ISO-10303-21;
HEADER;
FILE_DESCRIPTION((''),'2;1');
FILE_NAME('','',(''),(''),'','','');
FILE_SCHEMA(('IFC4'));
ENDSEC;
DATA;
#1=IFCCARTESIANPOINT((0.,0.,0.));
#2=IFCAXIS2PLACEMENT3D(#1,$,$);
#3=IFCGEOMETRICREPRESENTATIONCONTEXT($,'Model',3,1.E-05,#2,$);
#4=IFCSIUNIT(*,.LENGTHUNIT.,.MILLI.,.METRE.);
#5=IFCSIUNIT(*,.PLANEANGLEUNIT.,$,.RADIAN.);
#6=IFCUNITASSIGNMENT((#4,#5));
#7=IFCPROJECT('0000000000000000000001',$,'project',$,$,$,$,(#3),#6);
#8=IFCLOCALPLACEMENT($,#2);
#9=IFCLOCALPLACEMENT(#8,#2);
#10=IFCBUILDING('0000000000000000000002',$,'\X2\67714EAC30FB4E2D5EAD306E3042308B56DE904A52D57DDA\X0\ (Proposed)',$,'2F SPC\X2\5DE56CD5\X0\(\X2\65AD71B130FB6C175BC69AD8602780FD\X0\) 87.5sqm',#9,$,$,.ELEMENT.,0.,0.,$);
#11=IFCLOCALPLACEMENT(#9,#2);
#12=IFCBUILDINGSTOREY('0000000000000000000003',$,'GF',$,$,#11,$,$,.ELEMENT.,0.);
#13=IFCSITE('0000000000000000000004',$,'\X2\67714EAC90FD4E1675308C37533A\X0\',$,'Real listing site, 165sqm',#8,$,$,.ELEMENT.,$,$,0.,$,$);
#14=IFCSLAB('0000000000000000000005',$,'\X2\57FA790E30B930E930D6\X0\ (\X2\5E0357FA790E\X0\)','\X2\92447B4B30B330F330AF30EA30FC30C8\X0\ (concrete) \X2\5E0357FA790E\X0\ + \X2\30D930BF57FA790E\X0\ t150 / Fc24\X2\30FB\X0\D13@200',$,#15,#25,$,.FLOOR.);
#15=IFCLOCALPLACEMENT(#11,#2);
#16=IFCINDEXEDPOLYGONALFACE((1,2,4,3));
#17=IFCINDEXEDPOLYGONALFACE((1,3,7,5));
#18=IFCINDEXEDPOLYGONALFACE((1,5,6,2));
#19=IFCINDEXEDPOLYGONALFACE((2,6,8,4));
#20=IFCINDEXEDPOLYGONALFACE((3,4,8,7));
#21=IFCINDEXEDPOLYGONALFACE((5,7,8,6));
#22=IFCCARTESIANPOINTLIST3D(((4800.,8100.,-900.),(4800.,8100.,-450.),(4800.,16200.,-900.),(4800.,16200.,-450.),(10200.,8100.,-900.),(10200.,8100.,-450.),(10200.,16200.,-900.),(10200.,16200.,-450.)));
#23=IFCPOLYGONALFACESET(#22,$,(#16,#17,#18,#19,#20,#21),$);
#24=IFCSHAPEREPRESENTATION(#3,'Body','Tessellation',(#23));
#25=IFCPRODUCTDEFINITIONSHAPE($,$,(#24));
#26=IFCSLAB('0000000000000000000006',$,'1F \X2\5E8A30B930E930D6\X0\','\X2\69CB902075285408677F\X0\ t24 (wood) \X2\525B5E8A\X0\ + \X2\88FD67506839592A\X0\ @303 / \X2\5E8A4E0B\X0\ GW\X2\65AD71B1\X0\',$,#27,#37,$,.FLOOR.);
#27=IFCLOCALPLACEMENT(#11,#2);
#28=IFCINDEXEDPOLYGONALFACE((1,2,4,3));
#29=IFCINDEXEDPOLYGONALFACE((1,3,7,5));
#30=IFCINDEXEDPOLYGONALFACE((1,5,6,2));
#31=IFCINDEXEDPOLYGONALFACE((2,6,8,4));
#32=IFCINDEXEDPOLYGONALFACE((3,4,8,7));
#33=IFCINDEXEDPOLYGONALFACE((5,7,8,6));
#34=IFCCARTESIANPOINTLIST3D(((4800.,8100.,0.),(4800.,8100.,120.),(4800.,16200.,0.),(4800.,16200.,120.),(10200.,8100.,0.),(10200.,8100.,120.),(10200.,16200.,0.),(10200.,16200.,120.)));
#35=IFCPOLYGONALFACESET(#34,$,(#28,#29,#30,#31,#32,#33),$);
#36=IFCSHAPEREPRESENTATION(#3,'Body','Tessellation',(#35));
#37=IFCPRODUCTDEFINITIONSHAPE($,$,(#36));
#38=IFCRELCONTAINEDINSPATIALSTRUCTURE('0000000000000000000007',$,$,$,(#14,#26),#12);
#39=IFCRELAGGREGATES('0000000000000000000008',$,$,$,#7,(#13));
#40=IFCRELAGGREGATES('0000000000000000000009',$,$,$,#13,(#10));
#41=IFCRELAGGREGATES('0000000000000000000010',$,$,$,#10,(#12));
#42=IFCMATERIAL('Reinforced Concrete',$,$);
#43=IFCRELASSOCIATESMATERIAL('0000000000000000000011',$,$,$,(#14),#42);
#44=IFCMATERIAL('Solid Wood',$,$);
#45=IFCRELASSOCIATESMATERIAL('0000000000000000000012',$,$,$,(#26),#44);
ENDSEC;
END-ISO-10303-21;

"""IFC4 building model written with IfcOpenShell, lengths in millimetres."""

from ifc_helpers import new_model, si_unit, frame, frame_2d, origin, place, context, project, spatial, rectangle, extrude, material, element, save


model = new_model("IFC4")

# Units and contexts
model_context = context("Model", 3, precision=1e-05, world=origin())
ifc_project = project(units=[si_unit("LENGTHUNIT", "METRE", prefix="MILLI"), si_unit("PLANEANGLEUNIT", "RADIAN")], contexts=[model_context])

# Site, building, storey
site_placement = place(None, origin())
site = spatial("IfcSite", under=ifc_project, at=site_placement, Name="東京都世田谷区", ObjectType="Real listing site, 165sqm", CompositionType="ELEMENT", RefElevation=0.0)
building_placement = place(site_placement, origin())
building = spatial("IfcBuilding", under=site, at=building_placement, Name="東京・中庭のある回遊動線 (Proposed)", ObjectType="2F SPC工法(断熱・気密高性能) 87.5sqm", CompositionType="ELEMENT", ElevationOfRefHeight=0.0, ElevationOfTerrain=0.0)
storey_placement = place(building_placement, origin())
storey = spatial("IfcBuildingStorey", under=building, at=storey_placement, Name="GF", CompositionType="ELEMENT", Elevation=0.0)

# Shared definitions
ifc_material_1 = material(Name="Solid Wood")

# Slabs
ifc_material_2 = material(Name="Reinforced Concrete")
slab_1_placement = place(storey_placement, frame((2400.0, 4050.0, -450.0)))
element("IfcSlab", 1, at=slab_1_placement, inside=storey, material=ifc_material_2, Name="基礎スラブ (布基礎)", Description="鉄筋コンクリート (concrete) 布基礎 + ベタ基礎 t150 / Fc24・D13@200", PredefinedType="FLOOR", context=model_context, shape_type="SweptSolid", body=[
    extrude(rectangle(XDim=5400.0, YDim=8100.0, at=frame_2d((2700.0, 4050.0))), frame((2400.0, 4050.0, -450.0)), (0.0, 0.0, 1.0), 450.0),
])
slab_2_placement = place(storey_placement, frame((2400.0, 4050.0, 0.0)))
element("IfcSlab", 2, at=slab_2_placement, inside=storey, material=ifc_material_1, Name="1F 床スラブ", Description="構造用合板 t24 (wood) 剛床 + 製材根太 @303 / 床下 GW断熱", PredefinedType="FLOOR", context=model_context, shape_type="SweptSolid", body=[
    extrude(rectangle(XDim=5400.0, YDim=8100.0, at=frame_2d((2700.0, 4050.0))), frame((2400.0, 4050.0, 0.0)), (0.0, 0.0, 1.0), 120.0),
])

save(model, "model.ifc")
